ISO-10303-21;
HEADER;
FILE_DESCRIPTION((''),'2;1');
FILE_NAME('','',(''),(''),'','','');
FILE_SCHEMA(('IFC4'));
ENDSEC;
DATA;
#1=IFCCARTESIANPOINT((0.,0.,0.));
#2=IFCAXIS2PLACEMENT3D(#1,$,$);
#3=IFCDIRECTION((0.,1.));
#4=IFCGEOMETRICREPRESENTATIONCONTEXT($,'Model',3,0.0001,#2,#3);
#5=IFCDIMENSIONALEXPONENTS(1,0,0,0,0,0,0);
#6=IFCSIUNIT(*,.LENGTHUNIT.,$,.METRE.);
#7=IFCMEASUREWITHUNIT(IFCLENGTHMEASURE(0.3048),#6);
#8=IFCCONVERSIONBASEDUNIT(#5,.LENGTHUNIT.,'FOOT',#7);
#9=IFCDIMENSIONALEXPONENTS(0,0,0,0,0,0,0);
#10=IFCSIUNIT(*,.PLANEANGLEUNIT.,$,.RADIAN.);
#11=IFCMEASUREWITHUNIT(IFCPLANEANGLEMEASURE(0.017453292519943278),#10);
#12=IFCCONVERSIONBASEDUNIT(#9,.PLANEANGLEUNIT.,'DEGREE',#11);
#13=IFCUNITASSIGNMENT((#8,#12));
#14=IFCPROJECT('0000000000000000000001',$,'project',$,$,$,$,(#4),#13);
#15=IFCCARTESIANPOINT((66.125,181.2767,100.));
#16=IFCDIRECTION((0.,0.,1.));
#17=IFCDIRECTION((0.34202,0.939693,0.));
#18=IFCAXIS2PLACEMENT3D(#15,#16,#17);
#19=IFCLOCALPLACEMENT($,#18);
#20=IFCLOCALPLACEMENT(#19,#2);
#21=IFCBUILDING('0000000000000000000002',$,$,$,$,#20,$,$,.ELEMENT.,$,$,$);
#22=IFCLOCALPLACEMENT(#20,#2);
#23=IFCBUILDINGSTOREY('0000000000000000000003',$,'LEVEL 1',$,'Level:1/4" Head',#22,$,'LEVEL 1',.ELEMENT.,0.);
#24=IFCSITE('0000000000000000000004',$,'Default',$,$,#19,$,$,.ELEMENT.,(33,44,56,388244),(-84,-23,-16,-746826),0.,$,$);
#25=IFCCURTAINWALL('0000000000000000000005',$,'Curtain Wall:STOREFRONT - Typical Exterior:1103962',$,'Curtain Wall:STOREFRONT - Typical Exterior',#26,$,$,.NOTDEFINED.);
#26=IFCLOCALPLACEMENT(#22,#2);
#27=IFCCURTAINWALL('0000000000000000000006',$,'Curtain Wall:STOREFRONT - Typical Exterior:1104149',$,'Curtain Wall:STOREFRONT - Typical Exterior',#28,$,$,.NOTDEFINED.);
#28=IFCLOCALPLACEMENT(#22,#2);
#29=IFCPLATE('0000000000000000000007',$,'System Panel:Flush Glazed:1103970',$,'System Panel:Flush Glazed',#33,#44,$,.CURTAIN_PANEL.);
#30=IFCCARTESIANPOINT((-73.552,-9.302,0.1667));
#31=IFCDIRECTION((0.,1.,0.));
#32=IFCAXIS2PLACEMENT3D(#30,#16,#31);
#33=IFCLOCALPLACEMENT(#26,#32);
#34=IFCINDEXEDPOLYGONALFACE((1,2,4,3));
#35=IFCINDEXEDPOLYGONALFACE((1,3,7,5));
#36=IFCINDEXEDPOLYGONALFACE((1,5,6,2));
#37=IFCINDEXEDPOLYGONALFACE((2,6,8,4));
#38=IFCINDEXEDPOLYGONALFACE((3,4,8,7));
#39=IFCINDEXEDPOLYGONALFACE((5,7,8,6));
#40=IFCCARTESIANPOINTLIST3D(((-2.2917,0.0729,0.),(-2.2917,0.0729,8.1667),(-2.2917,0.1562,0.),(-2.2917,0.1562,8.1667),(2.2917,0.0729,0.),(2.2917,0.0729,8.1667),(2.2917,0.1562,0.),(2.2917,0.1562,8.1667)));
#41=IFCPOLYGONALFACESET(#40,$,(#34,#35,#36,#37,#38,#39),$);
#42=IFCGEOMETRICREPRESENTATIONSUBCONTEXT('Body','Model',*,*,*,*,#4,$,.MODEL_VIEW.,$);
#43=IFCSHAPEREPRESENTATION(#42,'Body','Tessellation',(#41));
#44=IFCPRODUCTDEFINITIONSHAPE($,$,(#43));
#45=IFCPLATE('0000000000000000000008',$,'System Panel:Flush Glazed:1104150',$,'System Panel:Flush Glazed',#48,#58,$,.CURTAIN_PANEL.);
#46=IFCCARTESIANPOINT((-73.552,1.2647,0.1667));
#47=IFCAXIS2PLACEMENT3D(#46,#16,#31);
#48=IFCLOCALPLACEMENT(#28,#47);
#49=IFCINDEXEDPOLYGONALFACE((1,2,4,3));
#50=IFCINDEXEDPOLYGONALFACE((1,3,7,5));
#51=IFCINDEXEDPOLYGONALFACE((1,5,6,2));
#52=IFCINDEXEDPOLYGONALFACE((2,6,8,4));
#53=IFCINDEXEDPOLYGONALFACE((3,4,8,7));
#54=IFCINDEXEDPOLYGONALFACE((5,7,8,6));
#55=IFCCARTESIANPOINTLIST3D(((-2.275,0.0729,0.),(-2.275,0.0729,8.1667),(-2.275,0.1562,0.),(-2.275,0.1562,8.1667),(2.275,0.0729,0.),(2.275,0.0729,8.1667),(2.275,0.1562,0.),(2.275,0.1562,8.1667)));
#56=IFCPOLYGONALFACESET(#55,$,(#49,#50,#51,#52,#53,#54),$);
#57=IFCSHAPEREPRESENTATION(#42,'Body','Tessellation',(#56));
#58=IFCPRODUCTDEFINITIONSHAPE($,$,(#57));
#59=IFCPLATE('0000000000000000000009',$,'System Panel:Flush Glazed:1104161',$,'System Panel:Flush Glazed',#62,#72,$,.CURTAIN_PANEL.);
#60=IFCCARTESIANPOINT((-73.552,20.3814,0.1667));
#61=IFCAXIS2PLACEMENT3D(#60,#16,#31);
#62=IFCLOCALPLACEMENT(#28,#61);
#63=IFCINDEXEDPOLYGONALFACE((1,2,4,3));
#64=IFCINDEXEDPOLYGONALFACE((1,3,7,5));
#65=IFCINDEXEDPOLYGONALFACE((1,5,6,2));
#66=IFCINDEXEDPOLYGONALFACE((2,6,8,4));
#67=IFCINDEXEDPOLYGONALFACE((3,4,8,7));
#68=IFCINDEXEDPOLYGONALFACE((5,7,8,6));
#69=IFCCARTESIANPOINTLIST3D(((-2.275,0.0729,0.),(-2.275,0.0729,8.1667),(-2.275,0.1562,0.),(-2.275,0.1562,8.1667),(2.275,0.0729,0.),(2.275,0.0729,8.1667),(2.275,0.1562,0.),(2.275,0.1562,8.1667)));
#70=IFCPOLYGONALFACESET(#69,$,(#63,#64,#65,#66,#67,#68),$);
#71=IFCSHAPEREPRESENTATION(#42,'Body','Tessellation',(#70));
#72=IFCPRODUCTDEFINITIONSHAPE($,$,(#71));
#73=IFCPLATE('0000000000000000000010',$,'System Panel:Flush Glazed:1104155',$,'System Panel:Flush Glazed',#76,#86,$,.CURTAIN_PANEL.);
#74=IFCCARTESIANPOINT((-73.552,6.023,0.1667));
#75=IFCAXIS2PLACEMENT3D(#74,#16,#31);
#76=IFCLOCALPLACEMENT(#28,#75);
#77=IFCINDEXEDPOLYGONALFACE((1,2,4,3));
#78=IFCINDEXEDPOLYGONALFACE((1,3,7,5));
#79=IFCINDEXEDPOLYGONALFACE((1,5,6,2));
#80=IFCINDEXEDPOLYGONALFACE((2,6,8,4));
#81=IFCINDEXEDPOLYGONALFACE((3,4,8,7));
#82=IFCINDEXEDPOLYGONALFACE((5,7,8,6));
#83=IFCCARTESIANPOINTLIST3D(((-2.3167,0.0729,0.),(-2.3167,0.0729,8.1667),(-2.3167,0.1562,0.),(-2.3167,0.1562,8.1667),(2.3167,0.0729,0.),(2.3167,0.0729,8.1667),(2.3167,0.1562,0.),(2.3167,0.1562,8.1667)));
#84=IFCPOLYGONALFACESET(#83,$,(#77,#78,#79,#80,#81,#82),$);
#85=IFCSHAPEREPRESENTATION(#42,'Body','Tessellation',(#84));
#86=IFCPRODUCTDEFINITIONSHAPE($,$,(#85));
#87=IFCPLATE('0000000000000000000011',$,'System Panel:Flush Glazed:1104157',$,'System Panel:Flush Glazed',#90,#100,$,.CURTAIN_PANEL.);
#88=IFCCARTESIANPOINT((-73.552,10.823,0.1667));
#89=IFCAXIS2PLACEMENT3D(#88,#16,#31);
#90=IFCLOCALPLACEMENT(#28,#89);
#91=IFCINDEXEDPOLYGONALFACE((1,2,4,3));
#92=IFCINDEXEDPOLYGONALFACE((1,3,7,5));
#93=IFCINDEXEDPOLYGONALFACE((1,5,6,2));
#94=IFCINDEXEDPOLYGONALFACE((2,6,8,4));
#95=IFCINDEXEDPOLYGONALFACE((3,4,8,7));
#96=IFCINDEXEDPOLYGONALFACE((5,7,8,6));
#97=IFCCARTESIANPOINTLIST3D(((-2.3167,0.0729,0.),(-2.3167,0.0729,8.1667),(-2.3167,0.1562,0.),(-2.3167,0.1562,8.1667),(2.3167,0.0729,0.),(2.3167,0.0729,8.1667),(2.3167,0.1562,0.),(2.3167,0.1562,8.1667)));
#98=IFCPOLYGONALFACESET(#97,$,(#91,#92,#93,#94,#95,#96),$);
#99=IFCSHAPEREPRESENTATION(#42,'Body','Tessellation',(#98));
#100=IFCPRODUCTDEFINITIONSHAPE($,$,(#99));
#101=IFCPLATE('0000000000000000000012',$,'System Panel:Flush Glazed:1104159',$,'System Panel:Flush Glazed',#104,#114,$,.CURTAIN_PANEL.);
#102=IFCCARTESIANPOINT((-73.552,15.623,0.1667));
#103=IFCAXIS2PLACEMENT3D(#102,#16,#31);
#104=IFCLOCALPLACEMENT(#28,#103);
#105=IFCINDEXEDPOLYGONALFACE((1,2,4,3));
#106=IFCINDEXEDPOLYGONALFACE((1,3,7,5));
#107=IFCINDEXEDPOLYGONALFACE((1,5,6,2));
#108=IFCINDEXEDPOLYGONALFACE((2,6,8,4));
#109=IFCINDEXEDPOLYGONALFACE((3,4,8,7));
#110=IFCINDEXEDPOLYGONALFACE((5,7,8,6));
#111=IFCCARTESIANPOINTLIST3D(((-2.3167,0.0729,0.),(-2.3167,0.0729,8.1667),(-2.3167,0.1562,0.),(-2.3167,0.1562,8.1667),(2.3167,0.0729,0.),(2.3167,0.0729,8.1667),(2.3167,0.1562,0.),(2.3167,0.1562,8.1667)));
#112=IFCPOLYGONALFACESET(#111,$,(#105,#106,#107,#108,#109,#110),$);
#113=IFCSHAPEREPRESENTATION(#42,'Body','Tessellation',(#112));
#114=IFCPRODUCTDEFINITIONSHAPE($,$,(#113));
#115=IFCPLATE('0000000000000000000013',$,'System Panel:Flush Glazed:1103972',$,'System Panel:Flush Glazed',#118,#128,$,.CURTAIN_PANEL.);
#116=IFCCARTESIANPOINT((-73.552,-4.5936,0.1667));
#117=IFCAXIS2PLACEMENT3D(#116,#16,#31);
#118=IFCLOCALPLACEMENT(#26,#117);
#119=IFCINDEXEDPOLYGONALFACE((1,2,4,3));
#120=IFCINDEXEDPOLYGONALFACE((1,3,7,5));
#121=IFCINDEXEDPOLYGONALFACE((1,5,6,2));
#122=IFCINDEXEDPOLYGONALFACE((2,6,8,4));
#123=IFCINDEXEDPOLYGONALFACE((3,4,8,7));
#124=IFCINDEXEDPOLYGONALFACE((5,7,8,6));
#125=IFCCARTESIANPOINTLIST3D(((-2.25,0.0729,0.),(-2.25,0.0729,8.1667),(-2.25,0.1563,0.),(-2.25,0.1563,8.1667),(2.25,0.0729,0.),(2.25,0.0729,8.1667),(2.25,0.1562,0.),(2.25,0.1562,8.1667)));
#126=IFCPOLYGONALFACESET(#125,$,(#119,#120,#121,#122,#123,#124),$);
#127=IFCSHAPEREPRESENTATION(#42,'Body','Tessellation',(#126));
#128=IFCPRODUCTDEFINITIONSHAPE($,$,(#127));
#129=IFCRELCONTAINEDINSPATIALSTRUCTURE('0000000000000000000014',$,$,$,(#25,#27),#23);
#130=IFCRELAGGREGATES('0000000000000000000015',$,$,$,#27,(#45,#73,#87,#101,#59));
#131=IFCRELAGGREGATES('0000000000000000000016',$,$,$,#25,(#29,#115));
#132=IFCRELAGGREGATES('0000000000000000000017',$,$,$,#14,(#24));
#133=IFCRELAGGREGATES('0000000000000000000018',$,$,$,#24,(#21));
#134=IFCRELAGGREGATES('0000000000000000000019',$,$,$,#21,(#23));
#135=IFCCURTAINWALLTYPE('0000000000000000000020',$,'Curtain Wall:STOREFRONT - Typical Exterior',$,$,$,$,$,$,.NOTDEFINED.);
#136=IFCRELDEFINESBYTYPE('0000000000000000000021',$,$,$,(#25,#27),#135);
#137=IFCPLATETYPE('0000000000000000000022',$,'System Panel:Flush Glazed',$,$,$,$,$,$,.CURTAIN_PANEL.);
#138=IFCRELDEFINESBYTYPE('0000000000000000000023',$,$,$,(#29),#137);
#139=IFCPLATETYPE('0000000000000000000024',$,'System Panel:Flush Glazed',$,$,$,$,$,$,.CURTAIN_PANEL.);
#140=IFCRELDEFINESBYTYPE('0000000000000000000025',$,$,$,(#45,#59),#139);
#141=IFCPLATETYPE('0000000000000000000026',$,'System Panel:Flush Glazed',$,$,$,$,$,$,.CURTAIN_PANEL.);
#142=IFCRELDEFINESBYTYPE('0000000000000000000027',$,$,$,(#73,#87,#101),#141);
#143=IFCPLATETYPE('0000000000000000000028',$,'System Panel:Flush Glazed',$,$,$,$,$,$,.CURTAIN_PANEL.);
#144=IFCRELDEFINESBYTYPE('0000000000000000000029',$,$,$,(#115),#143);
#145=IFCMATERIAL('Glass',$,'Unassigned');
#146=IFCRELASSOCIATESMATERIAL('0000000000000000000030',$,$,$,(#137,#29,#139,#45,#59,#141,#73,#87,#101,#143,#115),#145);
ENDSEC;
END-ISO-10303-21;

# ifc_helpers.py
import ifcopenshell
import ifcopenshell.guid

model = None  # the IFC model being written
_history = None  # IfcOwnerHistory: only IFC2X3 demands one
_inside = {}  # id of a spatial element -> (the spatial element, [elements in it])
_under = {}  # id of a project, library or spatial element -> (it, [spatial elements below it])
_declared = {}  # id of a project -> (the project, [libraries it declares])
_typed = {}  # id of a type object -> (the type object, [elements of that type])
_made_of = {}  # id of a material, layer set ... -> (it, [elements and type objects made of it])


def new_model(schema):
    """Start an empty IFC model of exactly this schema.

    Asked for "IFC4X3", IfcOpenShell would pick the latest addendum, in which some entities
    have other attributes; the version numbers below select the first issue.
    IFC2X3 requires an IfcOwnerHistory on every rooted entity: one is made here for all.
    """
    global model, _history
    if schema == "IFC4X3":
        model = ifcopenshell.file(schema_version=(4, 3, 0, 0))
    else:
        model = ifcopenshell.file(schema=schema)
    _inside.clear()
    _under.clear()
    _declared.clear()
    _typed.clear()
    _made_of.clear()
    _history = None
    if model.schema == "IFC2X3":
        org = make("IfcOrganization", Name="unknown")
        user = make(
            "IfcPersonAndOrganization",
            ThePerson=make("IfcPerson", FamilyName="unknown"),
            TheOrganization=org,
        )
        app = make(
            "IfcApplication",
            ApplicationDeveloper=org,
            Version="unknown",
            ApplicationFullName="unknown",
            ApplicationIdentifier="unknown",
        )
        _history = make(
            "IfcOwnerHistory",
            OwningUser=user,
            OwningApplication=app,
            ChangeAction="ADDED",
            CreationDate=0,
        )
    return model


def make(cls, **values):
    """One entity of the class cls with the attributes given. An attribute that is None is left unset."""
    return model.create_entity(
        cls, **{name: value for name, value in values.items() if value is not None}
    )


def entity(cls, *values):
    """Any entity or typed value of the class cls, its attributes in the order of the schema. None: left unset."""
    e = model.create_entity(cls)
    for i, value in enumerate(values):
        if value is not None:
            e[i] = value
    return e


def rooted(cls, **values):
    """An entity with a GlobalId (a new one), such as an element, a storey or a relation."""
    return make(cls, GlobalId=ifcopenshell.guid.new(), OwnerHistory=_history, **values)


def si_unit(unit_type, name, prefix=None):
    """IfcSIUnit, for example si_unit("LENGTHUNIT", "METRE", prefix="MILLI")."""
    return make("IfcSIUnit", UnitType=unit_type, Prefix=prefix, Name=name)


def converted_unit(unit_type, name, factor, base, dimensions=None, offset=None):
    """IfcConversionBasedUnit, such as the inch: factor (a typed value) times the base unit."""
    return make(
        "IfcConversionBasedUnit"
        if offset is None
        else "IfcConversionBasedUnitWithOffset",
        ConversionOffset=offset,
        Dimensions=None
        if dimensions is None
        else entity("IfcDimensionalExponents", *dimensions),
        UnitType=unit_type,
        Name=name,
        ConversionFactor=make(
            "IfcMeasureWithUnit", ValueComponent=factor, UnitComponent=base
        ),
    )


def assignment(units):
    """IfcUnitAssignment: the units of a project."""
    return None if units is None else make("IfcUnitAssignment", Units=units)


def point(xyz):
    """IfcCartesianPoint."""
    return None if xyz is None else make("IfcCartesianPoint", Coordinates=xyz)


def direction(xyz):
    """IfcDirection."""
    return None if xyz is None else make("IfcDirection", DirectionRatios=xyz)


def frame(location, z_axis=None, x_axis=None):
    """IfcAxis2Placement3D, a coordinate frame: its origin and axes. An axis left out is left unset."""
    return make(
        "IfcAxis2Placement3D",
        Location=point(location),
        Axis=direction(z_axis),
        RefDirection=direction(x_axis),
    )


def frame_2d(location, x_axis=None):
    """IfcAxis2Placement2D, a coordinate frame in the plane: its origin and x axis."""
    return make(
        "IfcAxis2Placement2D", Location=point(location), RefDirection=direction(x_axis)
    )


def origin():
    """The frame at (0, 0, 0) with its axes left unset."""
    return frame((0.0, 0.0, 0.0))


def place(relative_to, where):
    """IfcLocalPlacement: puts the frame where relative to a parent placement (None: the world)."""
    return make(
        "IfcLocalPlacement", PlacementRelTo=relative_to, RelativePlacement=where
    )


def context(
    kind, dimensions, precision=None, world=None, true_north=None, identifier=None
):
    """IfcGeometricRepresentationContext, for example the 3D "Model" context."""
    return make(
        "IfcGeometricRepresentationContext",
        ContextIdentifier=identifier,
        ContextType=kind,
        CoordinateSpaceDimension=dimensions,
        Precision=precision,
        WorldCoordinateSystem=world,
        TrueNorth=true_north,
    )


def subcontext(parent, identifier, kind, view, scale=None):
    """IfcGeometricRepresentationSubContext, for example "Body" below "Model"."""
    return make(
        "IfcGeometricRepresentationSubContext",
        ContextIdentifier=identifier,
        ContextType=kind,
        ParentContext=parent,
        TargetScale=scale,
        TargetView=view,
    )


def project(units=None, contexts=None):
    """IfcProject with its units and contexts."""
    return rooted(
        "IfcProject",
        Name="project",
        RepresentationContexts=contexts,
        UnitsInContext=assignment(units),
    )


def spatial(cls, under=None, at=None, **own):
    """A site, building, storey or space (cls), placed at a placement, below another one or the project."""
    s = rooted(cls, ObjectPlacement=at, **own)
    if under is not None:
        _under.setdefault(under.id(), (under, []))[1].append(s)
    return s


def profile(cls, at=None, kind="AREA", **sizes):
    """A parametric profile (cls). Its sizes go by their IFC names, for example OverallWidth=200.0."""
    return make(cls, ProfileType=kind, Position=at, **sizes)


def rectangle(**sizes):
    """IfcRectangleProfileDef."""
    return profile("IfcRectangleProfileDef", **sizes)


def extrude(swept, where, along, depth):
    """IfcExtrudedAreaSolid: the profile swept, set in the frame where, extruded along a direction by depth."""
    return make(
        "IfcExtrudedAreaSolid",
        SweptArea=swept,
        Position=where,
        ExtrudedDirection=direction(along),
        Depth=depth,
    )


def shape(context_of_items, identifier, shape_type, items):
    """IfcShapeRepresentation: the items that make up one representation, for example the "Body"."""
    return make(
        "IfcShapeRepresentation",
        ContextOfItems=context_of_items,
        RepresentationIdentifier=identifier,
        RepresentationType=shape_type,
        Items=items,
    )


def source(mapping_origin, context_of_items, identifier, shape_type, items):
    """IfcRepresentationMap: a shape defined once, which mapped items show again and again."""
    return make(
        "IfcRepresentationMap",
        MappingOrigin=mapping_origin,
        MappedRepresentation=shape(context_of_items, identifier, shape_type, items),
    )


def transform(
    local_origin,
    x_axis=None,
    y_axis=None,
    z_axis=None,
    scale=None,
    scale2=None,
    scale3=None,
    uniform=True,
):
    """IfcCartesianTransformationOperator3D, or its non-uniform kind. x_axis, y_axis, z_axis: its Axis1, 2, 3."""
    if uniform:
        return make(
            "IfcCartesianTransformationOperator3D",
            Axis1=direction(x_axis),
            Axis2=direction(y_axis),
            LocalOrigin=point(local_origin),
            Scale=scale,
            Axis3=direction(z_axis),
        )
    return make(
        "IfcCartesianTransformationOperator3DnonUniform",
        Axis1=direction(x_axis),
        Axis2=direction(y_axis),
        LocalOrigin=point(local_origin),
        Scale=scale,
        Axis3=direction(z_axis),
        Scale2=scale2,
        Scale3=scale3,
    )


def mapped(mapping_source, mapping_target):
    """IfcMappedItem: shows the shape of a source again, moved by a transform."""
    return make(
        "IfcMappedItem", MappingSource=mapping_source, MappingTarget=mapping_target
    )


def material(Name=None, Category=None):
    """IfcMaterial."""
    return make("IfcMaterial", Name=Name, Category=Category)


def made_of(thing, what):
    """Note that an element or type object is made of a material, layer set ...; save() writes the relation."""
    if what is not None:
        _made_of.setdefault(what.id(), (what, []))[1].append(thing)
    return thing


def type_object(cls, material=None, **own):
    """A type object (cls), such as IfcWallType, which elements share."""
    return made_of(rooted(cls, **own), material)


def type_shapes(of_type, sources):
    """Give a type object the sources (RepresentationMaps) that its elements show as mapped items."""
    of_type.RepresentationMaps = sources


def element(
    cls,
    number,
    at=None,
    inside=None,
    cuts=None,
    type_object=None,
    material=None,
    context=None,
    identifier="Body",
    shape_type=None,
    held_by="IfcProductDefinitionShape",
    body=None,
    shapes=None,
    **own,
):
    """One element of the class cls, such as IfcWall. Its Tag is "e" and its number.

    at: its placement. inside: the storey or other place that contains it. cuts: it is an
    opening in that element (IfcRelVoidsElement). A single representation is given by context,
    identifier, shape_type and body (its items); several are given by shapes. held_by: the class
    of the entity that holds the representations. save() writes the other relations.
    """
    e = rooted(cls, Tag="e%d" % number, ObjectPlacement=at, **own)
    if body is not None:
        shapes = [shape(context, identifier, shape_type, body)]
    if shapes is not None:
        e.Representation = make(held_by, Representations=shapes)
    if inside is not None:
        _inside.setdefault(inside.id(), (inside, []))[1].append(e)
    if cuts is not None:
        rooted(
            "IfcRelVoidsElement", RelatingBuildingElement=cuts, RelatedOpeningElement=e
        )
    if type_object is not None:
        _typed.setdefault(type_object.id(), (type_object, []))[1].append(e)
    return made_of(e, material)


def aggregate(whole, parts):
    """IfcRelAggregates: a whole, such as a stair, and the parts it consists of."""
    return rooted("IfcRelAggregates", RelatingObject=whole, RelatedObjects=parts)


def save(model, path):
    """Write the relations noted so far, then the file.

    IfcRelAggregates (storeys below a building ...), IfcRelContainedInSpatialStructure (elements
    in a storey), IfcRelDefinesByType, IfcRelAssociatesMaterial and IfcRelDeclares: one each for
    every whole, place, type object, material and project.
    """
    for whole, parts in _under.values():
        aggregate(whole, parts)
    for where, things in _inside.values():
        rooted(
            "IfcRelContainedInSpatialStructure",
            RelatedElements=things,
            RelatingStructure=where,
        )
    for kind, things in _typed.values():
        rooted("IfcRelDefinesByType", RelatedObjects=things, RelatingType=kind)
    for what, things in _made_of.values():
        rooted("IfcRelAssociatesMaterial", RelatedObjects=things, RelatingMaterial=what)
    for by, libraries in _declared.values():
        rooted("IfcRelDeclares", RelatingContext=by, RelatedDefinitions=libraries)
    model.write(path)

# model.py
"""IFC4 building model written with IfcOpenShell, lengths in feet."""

from ifc_helpers import new_model, entity, si_unit, converted_unit, direction, frame, frame_2d, origin, place, context, subcontext, project, spatial, rectangle, extrude, source, transform, mapped, material, type_object, type_shapes, element, aggregate, save


model = new_model("IFC4")

# Units and contexts
model_context = context("Model", 3, precision=0.0001, world=origin(), true_north=direction((0.0, 1.0)))
body_context = subcontext(model_context, "Body", "Model", "MODEL_VIEW")
ifc_project = project(units=[converted_unit("LENGTHUNIT", "FOOT", entity("IfcLengthMeasure", 0.3048), si_unit("LENGTHUNIT", "METRE"), dimensions=[1, 0, 0, 0, 0, 0, 0]), converted_unit("PLANEANGLEUNIT", "DEGREE", entity("IfcPlaneAngleMeasure", 0.017453292519943278), si_unit("PLANEANGLEUNIT", "RADIAN"), dimensions=[0, 0, 0, 0, 0, 0, 0])], contexts=[model_context])

# Site, building, storey
site_placement = place(None, frame((66.125, 181.2767, 100.0), z_axis=(0.0, 0.0, 1.0), x_axis=(0.34202, 0.939693, 0.0)))
site = spatial("IfcSite", under=ifc_project, at=site_placement, Name="Default", CompositionType="ELEMENT", RefLatitude=(33, 44, 56, 388244), RefLongitude=(-84, -23, -16, -746826), RefElevation=0.0)
building_placement = place(site_placement, origin())
building = spatial("IfcBuilding", under=site, at=building_placement, CompositionType="ELEMENT")
storey_placement = place(building_placement, origin())
storey = spatial("IfcBuildingStorey", under=building, at=storey_placement, Name="LEVEL 1", ObjectType="Level:1/4\" Head", LongName="LEVEL 1", CompositionType="ELEMENT", Elevation=0.0)

# Curtain wall
curtain_wall_type = type_object("IfcCurtainWallType", Name="Curtain Wall:STOREFRONT - Typical Exterior", PredefinedType="NOTDEFINED")
curtain_wall_1_placement = place(storey_placement, origin())
curtain_wall_1 = element("IfcCurtainWall", 1, at=curtain_wall_1_placement, inside=storey, type_object=curtain_wall_type, Name="Curtain Wall:STOREFRONT - Typical Exterior:1103962", ObjectType="Curtain Wall:STOREFRONT - Typical Exterior", PredefinedType="NOTDEFINED")

# Curtain wall
curtain_wall_2_placement = place(storey_placement, origin())
curtain_wall_2 = element("IfcCurtainWall", 2, at=curtain_wall_2_placement, inside=storey, type_object=curtain_wall_type, Name="Curtain Wall:STOREFRONT - Typical Exterior:1104149", ObjectType="Curtain Wall:STOREFRONT - Typical Exterior", PredefinedType="NOTDEFINED")

# Plates
ifc_material_1 = material(Name="Glass", Category="Unassigned")
plate_type_1 = type_object("IfcPlateType", Name="System Panel:Flush Glazed", PredefinedType="CURTAIN_PANEL", material=ifc_material_1)
shared_shape_1 = source(origin(), body_context, "Body", "SweptSolid", [
    extrude(rectangle(XDim=0.0833, YDim=4.5833, at=frame_2d((0.0, 0.0), x_axis=(1.0, 0.0))), frame((0.0, 0.1146, 0.0), z_axis=(0.0, 0.0, 1.0), x_axis=(0.0, 1.0, 0.0)), (0.0, 0.0, 1.0), 8.1667),
])
type_shapes(plate_type_1, [shared_shape_1])
plate_1_placement = place(curtain_wall_1_placement, frame((-73.552, -9.302, 0.1667), z_axis=(0.0, 0.0, 1.0), x_axis=(0.0, 1.0, 0.0)))
plate_1 = element("IfcPlate", 3, at=plate_1_placement, type_object=plate_type_1, material=ifc_material_1, Name="System Panel:Flush Glazed:1103970", ObjectType="System Panel:Flush Glazed", PredefinedType="CURTAIN_PANEL", context=body_context, shape_type="MappedRepresentation", body=[
    mapped(shared_shape_1, transform((0.0, 0.0, 0.0), scale=1.0)),
])
plate_type_2 = type_object("IfcPlateType", Name="System Panel:Flush Glazed", PredefinedType="CURTAIN_PANEL", material=ifc_material_1)
shared_shape_2 = source(origin(), body_context, "Body", "SweptSolid", [
    extrude(rectangle(XDim=0.0833, YDim=4.55, at=frame_2d((0.0, 0.0), x_axis=(1.0, 0.0))), frame((0.0, 0.1146, 0.0), z_axis=(0.0, 0.0, 1.0), x_axis=(0.0, 1.0, 0.0)), (0.0, 0.0, 1.0), 8.1667),
])
type_shapes(plate_type_2, [shared_shape_2])
plate_2_placement = place(curtain_wall_2_placement, frame((-73.552, 1.2647, 0.1667), z_axis=(0.0, 0.0, 1.0), x_axis=(0.0, 1.0, 0.0)))
plate_2 = element("IfcPlate", 4, at=plate_2_placement, type_object=plate_type_2, material=ifc_material_1, Name="System Panel:Flush Glazed:1104150", ObjectType="System Panel:Flush Glazed", PredefinedType="CURTAIN_PANEL", context=body_context, shape_type="MappedRepresentation", body=[
    mapped(shared_shape_2, transform((0.0, 0.0, 0.0), scale=1.0)),
])
plate_3_placement = place(curtain_wall_2_placement, frame((-73.552, 20.3814, 0.1667), z_axis=(0.0, 0.0, 1.0), x_axis=(0.0, 1.0, 0.0)))
plate_3 = element("IfcPlate", 5, at=plate_3_placement, type_object=plate_type_2, material=ifc_material_1, Name="System Panel:Flush Glazed:1104161", ObjectType="System Panel:Flush Glazed", PredefinedType="CURTAIN_PANEL", context=body_context, shape_type="MappedRepresentation", body=[
    mapped(shared_shape_2, transform((0.0, 0.0, 0.0), scale=1.0)),
])
plate_type_3 = type_object("IfcPlateType", Name="System Panel:Flush Glazed", PredefinedType="CURTAIN_PANEL", material=ifc_material_1)
shared_shape_3 = source(origin(), body_context, "Body", "SweptSolid", [
    extrude(rectangle(XDim=0.0833, YDim=4.6333, at=frame_2d((0.0, 0.0), x_axis=(1.0, 0.0))), frame((0.0, 0.1146, 0.0), z_axis=(0.0, 0.0, 1.0), x_axis=(0.0, 1.0, 0.0)), (0.0, 0.0, 1.0), 8.1667),
])
type_shapes(plate_type_3, [shared_shape_3])
plate_4_placement = place(curtain_wall_2_placement, frame((-73.552, 6.023, 0.1667), z_axis=(0.0, 0.0, 1.0), x_axis=(0.0, 1.0, 0.0)))
plate_4 = element("IfcPlate", 6, at=plate_4_placement, type_object=plate_type_3, material=ifc_material_1, Name="System Panel:Flush Glazed:1104155", ObjectType="System Panel:Flush Glazed", PredefinedType="CURTAIN_PANEL", context=body_context, shape_type="MappedRepresentation", body=[
    mapped(shared_shape_3, transform((0.0, 0.0, 0.0), scale=1.0)),
])
plate_5_placement = place(curtain_wall_2_placement, frame((-73.552, 10.823, 0.1667), z_axis=(0.0, 0.0, 1.0), x_axis=(0.0, 1.0, 0.0)))
plate_5 = element("IfcPlate", 7, at=plate_5_placement, type_object=plate_type_3, material=ifc_material_1, Name="System Panel:Flush Glazed:1104157", ObjectType="System Panel:Flush Glazed", PredefinedType="CURTAIN_PANEL", context=body_context, shape_type="MappedRepresentation", body=[
    mapped(shared_shape_3, transform((0.0, 0.0, 0.0), scale=1.0)),
])
plate_6_placement = place(curtain_wall_2_placement, frame((-73.552, 15.623, 0.1667), z_axis=(0.0, 0.0, 1.0), x_axis=(0.0, 1.0, 0.0)))
plate_6 = element("IfcPlate", 8, at=plate_6_placement, type_object=plate_type_3, material=ifc_material_1, Name="System Panel:Flush Glazed:1104159", ObjectType="System Panel:Flush Glazed", PredefinedType="CURTAIN_PANEL", context=body_context, shape_type="MappedRepresentation", body=[
    mapped(shared_shape_3, transform((0.0, 0.0, 0.0), scale=1.0)),
])
aggregate(curtain_wall_2, [plate_2, plate_4, plate_5, plate_6, plate_3])
plate_type_4 = type_object("IfcPlateType", Name="System Panel:Flush Glazed", PredefinedType="CURTAIN_PANEL", material=ifc_material_1)
shared_shape_4 = source(origin(), body_context, "Body", "SweptSolid", [
    extrude(rectangle(XDim=0.0833, YDim=4.5, at=frame_2d((0.0, 0.0), x_axis=(1.0, 0.0))), frame((0.0, 0.1146, 0.0), z_axis=(0.0, 0.0, 1.0), x_axis=(0.0, 1.0, 0.0)), (0.0, 0.0, 1.0), 8.1667),
])
type_shapes(plate_type_4, [shared_shape_4])
plate_7_placement = place(curtain_wall_1_placement, frame((-73.552, -4.5936, 0.1667), z_axis=(0.0, 0.0, 1.0), x_axis=(0.0, 1.0, 0.0)))
plate_7 = element("IfcPlate", 9, at=plate_7_placement, type_object=plate_type_4, material=ifc_material_1, Name="System Panel:Flush Glazed:1103972", ObjectType="System Panel:Flush Glazed", PredefinedType="CURTAIN_PANEL", context=body_context, shape_type="MappedRepresentation", body=[
    mapped(shared_shape_4, transform((0.0, 0.0, 0.0), scale=1.0)),
])
aggregate(curtain_wall_1, [plate_1, plate_7])

save(model, "model.ifc")
